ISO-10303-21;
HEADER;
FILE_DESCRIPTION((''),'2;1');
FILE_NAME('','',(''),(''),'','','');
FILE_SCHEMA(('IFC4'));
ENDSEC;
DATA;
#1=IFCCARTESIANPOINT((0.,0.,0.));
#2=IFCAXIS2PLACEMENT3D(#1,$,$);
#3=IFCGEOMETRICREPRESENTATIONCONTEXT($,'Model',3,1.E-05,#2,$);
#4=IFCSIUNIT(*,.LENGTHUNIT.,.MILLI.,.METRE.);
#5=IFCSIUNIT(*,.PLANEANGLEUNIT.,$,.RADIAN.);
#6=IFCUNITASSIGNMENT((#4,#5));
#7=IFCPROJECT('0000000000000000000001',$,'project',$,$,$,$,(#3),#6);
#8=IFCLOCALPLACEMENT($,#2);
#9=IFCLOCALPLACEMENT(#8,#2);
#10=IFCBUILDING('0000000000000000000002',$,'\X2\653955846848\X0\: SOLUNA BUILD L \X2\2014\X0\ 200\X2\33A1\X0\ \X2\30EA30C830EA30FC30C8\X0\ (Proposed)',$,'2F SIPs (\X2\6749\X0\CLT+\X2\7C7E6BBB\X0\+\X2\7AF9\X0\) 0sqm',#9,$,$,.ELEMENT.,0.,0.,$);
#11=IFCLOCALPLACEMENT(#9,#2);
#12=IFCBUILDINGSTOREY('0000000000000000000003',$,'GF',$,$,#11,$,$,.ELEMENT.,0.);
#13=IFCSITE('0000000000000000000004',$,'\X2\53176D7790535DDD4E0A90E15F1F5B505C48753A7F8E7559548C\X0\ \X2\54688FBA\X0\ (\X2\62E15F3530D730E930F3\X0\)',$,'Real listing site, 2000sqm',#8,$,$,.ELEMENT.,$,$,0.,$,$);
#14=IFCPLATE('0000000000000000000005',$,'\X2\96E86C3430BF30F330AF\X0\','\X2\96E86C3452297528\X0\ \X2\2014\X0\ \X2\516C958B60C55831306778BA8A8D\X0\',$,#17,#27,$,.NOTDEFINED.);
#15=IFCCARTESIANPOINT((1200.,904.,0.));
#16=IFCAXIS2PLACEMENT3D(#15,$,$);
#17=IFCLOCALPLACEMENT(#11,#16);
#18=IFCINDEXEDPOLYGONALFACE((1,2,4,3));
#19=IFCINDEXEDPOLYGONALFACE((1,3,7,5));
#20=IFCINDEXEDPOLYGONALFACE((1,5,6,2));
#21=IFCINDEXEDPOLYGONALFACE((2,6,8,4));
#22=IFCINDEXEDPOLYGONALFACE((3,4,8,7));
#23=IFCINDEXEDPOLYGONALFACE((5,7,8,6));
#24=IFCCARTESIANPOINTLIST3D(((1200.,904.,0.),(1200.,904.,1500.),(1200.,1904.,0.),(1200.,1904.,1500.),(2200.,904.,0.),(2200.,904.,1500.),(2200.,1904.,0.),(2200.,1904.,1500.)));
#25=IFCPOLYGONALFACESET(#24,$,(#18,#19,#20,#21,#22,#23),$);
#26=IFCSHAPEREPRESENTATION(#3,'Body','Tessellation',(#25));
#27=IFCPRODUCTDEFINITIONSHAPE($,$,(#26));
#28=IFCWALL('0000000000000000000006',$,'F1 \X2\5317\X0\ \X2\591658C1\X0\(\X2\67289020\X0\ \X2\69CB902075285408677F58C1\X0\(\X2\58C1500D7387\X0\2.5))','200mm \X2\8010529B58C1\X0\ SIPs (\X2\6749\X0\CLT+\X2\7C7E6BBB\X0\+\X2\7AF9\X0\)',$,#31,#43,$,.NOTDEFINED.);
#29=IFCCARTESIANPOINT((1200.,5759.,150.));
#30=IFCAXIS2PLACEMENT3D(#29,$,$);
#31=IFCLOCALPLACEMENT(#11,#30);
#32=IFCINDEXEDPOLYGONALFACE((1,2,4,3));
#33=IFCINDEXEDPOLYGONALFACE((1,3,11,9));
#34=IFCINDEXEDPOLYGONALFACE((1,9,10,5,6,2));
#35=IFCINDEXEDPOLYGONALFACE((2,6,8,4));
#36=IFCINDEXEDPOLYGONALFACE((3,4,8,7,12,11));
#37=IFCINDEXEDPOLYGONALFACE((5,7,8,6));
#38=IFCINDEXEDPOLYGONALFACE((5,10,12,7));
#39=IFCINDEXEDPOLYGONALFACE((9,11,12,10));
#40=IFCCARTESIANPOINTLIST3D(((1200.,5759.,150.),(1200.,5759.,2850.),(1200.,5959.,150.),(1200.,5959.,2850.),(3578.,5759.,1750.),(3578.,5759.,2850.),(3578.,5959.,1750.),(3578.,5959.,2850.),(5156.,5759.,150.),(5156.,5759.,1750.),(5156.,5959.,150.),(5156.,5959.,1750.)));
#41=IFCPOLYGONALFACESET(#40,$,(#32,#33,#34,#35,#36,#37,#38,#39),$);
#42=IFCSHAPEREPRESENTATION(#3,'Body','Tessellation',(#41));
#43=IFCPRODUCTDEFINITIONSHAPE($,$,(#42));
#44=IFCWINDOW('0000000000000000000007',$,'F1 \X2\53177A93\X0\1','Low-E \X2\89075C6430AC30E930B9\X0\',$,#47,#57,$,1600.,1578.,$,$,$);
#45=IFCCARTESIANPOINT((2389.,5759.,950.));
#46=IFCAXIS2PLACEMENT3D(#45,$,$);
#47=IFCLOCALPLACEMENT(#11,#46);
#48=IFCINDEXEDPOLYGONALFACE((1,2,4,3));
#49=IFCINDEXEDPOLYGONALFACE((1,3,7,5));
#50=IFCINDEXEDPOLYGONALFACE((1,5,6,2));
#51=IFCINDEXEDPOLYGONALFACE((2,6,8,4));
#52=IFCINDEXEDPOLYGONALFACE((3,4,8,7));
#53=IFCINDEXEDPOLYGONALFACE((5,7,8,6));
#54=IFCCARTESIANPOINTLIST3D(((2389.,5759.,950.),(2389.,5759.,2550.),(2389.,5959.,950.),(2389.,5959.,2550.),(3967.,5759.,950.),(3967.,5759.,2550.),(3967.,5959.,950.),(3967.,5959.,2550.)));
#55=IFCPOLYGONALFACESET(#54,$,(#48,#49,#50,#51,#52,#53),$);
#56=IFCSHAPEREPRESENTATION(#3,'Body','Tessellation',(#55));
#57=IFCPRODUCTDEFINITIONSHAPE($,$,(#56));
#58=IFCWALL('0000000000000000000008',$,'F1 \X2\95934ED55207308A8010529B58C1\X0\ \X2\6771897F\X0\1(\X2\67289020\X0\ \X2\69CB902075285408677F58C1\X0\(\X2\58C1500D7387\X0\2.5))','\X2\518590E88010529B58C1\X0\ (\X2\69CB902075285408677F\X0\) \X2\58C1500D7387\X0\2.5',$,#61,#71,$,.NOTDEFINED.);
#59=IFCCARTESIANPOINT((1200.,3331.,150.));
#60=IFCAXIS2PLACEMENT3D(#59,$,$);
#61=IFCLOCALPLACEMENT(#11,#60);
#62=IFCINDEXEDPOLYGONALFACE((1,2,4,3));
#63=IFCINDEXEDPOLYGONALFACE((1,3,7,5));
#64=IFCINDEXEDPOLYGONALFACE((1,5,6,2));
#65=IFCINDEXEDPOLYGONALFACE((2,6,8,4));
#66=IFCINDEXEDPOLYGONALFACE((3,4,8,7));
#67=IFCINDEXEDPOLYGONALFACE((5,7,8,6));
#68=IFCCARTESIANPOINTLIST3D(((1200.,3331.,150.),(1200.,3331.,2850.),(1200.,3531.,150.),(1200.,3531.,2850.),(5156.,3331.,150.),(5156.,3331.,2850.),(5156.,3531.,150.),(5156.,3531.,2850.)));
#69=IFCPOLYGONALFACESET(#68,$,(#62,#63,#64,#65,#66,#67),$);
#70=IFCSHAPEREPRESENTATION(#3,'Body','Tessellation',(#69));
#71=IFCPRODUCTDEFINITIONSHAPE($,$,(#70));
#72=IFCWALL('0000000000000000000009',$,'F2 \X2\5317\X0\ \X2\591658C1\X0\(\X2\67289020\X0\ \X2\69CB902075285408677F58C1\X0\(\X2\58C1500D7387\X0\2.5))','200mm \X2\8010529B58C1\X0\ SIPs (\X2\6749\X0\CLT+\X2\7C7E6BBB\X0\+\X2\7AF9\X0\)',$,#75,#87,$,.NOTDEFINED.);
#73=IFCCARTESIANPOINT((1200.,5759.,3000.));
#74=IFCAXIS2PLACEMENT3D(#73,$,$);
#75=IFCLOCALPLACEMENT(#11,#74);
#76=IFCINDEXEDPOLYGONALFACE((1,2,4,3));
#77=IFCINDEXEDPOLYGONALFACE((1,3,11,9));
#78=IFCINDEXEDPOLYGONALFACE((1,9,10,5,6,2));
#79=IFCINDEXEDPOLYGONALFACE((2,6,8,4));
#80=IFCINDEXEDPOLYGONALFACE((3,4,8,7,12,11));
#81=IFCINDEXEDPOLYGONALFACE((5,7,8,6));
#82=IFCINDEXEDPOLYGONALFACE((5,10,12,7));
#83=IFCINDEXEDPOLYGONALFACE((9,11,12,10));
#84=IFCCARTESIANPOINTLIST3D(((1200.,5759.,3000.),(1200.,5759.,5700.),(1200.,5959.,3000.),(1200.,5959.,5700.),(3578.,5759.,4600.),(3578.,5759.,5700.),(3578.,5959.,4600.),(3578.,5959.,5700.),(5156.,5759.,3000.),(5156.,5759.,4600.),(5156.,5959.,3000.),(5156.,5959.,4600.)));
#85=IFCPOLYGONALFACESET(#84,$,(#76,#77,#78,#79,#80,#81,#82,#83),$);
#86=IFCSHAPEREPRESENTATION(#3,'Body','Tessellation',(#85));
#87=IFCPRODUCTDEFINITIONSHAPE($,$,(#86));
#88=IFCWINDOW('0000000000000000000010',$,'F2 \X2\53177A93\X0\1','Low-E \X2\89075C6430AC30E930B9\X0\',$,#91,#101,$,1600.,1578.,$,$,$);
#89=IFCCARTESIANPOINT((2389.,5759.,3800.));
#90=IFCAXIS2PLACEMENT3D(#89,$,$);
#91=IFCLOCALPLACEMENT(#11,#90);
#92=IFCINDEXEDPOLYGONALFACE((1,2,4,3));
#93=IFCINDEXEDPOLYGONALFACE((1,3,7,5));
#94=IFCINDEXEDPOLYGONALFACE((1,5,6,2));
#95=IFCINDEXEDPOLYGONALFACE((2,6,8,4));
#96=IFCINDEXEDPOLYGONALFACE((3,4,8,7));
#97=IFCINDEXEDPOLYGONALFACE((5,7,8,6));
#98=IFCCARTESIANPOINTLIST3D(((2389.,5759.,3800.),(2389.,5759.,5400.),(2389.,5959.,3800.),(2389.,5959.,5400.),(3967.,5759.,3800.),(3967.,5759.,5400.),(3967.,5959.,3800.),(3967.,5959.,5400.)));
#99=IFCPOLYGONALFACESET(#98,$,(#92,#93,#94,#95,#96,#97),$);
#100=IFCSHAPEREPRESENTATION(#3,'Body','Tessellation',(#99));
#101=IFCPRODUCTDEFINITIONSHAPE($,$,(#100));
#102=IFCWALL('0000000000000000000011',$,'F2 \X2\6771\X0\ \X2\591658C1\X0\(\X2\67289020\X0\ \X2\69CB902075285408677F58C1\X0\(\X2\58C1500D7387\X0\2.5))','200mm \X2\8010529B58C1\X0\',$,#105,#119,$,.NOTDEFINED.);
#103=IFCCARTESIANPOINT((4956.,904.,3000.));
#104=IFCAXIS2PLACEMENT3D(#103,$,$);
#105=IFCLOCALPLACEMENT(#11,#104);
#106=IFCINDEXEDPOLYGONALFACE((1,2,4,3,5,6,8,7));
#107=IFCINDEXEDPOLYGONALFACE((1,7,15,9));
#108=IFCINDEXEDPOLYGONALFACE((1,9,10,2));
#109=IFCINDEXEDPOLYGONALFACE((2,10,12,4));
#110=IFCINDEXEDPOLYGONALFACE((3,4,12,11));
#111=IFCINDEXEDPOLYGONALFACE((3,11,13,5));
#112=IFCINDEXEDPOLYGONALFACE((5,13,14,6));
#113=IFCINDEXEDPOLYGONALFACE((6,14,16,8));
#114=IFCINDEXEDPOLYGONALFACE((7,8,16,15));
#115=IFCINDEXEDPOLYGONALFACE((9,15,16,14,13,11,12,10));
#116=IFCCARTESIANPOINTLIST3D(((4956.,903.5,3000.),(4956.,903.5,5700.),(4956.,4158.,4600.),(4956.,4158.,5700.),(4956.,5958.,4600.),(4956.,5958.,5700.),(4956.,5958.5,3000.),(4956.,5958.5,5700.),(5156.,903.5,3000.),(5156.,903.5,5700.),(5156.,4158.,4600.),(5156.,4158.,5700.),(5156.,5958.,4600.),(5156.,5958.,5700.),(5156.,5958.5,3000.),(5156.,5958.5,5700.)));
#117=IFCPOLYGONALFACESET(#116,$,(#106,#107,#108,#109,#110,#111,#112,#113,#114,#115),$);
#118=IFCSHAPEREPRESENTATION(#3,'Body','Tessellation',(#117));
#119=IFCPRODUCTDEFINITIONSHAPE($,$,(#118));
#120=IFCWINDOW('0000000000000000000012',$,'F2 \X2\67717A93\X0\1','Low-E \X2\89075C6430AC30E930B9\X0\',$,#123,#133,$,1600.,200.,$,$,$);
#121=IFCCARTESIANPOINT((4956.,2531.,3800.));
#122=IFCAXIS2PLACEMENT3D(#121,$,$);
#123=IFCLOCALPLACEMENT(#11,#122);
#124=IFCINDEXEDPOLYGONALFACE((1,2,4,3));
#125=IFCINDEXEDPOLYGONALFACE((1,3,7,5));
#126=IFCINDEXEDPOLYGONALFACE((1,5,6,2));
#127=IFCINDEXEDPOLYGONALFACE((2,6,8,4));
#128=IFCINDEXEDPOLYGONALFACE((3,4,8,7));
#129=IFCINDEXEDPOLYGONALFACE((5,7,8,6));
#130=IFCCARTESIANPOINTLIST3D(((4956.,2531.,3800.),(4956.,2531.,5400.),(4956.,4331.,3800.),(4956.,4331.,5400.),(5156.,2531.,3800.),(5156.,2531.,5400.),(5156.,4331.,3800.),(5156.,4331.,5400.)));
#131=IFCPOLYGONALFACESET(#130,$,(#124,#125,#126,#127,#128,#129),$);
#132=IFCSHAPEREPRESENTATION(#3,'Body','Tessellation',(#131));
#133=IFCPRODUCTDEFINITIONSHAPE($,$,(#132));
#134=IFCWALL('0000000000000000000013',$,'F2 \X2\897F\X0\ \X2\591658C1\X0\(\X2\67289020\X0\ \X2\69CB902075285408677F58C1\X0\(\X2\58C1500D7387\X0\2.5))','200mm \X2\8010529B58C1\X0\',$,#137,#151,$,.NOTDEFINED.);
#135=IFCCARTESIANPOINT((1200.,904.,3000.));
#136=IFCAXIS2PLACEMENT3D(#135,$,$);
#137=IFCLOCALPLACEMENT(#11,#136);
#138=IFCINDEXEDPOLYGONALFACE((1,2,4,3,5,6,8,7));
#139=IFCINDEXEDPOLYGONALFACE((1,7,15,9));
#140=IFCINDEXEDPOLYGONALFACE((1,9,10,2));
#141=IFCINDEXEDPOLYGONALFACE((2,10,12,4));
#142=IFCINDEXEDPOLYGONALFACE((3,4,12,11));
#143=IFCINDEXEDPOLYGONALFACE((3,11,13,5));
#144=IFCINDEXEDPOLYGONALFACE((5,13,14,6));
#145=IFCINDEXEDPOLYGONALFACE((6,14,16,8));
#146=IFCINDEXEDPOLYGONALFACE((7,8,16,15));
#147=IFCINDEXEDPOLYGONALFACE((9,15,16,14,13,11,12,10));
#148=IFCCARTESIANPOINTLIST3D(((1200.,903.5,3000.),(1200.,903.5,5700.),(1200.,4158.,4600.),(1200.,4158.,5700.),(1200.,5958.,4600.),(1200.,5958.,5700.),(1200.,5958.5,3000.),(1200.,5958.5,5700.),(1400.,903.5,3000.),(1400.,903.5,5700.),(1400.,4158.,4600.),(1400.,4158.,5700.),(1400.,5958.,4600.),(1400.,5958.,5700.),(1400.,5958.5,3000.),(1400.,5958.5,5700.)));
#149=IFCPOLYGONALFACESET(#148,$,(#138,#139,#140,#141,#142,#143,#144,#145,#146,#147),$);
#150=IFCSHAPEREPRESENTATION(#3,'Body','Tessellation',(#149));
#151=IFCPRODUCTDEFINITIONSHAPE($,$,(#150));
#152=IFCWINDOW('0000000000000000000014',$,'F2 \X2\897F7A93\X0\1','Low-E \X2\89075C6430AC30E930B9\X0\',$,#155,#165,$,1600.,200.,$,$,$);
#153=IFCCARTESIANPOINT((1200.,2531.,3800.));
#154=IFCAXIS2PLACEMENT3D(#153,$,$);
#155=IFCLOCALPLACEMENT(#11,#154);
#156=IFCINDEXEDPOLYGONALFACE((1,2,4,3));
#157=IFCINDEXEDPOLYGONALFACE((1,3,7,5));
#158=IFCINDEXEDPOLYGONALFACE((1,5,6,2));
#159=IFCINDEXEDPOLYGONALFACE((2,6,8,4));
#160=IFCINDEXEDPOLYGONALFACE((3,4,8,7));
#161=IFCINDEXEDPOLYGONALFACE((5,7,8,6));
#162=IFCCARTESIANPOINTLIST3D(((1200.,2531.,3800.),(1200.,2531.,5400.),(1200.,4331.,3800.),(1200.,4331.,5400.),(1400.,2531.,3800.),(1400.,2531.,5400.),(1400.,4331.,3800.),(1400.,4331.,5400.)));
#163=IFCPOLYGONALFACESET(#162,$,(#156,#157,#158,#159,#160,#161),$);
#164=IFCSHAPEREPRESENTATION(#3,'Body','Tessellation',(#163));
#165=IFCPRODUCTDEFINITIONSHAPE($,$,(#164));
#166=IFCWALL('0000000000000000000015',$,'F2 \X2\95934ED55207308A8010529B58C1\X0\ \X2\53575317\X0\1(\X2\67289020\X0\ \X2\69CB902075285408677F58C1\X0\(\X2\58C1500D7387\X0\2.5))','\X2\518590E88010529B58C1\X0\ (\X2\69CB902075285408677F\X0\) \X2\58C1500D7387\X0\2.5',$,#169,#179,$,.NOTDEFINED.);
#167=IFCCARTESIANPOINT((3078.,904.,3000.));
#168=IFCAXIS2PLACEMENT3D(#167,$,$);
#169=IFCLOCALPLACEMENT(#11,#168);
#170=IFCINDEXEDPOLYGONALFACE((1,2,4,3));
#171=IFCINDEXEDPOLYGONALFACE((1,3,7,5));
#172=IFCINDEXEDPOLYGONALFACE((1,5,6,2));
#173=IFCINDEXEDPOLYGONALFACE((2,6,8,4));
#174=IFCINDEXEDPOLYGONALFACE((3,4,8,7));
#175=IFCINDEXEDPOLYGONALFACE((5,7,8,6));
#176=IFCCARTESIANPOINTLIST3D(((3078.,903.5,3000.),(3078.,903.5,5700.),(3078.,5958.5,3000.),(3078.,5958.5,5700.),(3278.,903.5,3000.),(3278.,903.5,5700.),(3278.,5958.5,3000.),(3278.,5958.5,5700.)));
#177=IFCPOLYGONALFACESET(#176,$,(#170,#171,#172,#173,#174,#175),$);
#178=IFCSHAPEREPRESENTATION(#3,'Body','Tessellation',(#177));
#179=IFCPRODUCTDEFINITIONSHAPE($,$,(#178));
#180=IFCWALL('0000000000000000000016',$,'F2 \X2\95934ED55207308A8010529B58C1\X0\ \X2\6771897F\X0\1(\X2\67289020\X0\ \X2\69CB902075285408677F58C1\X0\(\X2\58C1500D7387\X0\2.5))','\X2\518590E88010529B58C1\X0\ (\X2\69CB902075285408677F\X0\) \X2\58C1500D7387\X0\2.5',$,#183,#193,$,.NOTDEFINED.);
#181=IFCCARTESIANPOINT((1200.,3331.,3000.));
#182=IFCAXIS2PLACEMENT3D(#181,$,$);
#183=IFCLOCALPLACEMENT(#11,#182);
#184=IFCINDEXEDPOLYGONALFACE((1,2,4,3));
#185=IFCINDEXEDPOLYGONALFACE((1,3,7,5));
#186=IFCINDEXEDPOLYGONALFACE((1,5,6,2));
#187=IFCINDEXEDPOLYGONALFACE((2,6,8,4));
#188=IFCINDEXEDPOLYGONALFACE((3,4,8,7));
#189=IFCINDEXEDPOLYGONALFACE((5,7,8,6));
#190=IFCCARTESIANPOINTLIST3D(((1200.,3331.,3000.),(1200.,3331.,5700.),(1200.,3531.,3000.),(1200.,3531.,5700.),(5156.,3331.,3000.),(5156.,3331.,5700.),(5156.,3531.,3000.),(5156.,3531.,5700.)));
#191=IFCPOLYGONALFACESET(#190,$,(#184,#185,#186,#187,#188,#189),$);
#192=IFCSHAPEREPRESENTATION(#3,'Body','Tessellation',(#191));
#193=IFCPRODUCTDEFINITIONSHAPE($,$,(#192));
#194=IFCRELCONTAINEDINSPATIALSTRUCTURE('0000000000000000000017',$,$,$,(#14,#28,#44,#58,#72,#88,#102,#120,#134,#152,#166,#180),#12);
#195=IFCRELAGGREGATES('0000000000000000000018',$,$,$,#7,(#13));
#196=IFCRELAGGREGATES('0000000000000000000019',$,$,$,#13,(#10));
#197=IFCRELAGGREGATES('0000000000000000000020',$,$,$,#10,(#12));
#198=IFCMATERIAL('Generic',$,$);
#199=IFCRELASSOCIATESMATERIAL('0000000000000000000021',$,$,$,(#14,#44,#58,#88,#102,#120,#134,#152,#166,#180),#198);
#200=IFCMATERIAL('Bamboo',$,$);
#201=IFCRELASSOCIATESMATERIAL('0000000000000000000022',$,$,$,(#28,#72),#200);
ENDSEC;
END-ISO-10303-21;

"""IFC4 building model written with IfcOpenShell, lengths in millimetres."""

from ifc_helpers import new_model, si_unit, frame, frame_2d, origin, place, context, project, spatial, rectangle, extrude, material, element, fill, save


model = new_model("IFC4")

# Units and contexts
model_context = context("Model", 3, precision=1e-05, world=origin())
ifc_project = project(units=[si_unit("LENGTHUNIT", "METRE", prefix="MILLI"), si_unit("PLANEANGLEUNIT", "RADIAN")], contexts=[model_context])

# Site, building, storey
site_placement = place(None, origin())
site = spatial("IfcSite", under=ifc_project, at=site_placement, Name="北海道川上郡弟子屈町美留和 周辺 (拡張プラン)", ObjectType="Real listing site, 2000sqm", CompositionType="ELEMENT", RefElevation=0.0)
building_placement = place(site_placement, origin())
building = spatial("IfcBuilding", under=site, at=building_placement, Name="改善案: SOLUNA BUILD L — 200㎡ リトリート (Proposed)", ObjectType="2F SIPs (杉CLT+籾殻+竹) 0sqm", CompositionType="ELEMENT", ElevationOfRefHeight=0.0, ElevationOfTerrain=0.0)
storey_placement = place(building_placement, origin())
storey = spatial("IfcBuildingStorey", under=building, at=storey_placement, Name="GF", CompositionType="ELEMENT", Elevation=0.0)

# Plate
ifc_material_1 = material(Name="Generic")
plate_placement = place(storey_placement, frame((1200.0, 904.0, 0.0)))
element("IfcPlate", 1, at=plate_placement, inside=storey, material=ifc_material_1, Name="雨水タンク", Description="雨水利用 — 公開情報で確認", PredefinedType="NOTDEFINED", context=model_context, shape_type="SweptSolid", body=[
    extrude(rectangle(XDim=1000.0, YDim=1000.0, at=frame_2d((500.0, 500.0))), frame((1200.0, 904.0, 0.0)), (0.0, 0.0, 1.0), 1500.0),
])

# Wall, opening, window
ifc_material_2 = material(Name="Bamboo")
wall_1_placement = place(storey_placement, frame((1200.0, 5759.0, 150.0)))
wall_1 = element("IfcWall", 2, at=wall_1_placement, inside=storey, material=ifc_material_2, Name="F1 北 外壁(木造 構造用合板壁(壁倍率2.5))", Description="200mm 耐力壁 SIPs (杉CLT+籾殻+竹)", PredefinedType="NOTDEFINED", context=model_context, shape_type="SweptSolid", body=[
    extrude(rectangle(XDim=3956.0, YDim=200.0, at=frame_2d((1978.0, 100.0))), frame((1200.0, 5759.0, 150.0)), (0.0, 0.0, 1.0), 2700.0),
])
opening_1_placement = place(storey_placement, frame((2389.0, 5759.0, 950.0)))
opening_1 = element("IfcOpeningElement", 3, at=opening_1_placement, cuts=wall_1, PredefinedType="NOTDEFINED", context=model_context, shape_type="SweptSolid", body=[
    extrude(rectangle(XDim=1578.0, YDim=200.0, at=frame_2d((789.0, 100.0))), frame((2389.0, 5759.0, 950.0)), (0.0, 0.0, 1.0), 1600.0),
])
window_1_placement = place(storey_placement, frame((2389.0, 5759.0, 950.0)))
window_1 = element("IfcWindow", 4, at=window_1_placement, inside=storey, material=ifc_material_1, Name="F1 北窓1", Description="Low-E 複層ガラス", OverallHeight=1600.0, OverallWidth=1578.0, context=model_context, shape_type="SweptSolid", body=[
    extrude(rectangle(XDim=1578.0, YDim=200.0, at=frame_2d((789.0, 100.0))), frame((2389.0, 5759.0, 950.0)), (0.0, 0.0, 1.0), 1600.0),
])
fill(opening_1, window_1)

# Wall
wall_2_placement = place(storey_placement, frame((1200.0, 3331.0, 150.0)))
element("IfcWall", 5, at=wall_2_placement, inside=storey, material=ifc_material_1, Name="F1 間仕切り耐力壁 東西1(木造 構造用合板壁(壁倍率2.5))", Description="内部耐力壁 (構造用合板) 壁倍率2.5", PredefinedType="NOTDEFINED", context=model_context, shape_type="SweptSolid", body=[
    extrude(rectangle(XDim=3956.0, YDim=200.0, at=frame_2d((1978.0, 100.0))), frame((1200.0, 3331.0, 150.0)), (0.0, 0.0, 1.0), 2700.0),
])

# Walls, openings, windows
wall_3_placement = place(storey_placement, frame((1200.0, 5759.0, 3000.0)))
wall_3 = element("IfcWall", 6, at=wall_3_placement, inside=storey, material=ifc_material_2, Name="F2 北 外壁(木造 構造用合板壁(壁倍率2.5))", Description="200mm 耐力壁 SIPs (杉CLT+籾殻+竹)", PredefinedType="NOTDEFINED", context=model_context, shape_type="SweptSolid", body=[
    extrude(rectangle(XDim=3956.0, YDim=200.0, at=frame_2d((1978.0, 100.0))), frame((1200.0, 5759.0, 3000.0)), (0.0, 0.0, 1.0), 2700.0),
])
opening_2_placement = place(storey_placement, frame((2389.0, 5759.0, 3800.0)))
opening_2 = element("IfcOpeningElement", 7, at=opening_2_placement, cuts=wall_3, PredefinedType="NOTDEFINED", context=model_context, shape_type="SweptSolid", body=[
    extrude(rectangle(XDim=1578.0, YDim=200.0, at=frame_2d((789.0, 100.0))), frame((2389.0, 5759.0, 3800.0)), (0.0, 0.0, 1.0), 1600.0),
])
window_2_placement = place(storey_placement, frame((2389.0, 5759.0, 3800.0)))
window_2 = element("IfcWindow", 8, at=window_2_placement, inside=storey, material=ifc_material_1, Name="F2 北窓1", Description="Low-E 複層ガラス", OverallHeight=1600.0, OverallWidth=1578.0, context=model_context, shape_type="SweptSolid", body=[
    extrude(rectangle(XDim=1578.0, YDim=200.0, at=frame_2d((789.0, 100.0))), frame((2389.0, 5759.0, 3800.0)), (0.0, 0.0, 1.0), 1600.0),
])
fill(opening_2, window_2)
wall_4_placement = place(storey_placement, frame((4956.0, 904.0, 3000.0)))
wall_4 = element("IfcWall", 9, at=wall_4_placement, inside=storey, material=ifc_material_1, Name="F2 東 外壁(木造 構造用合板壁(壁倍率2.5))", Description="200mm 耐力壁", PredefinedType="NOTDEFINED", context=model_context, shape_type="SweptSolid", body=[
    extrude(rectangle(XDim=200.0, YDim=5055.0, at=frame_2d((100.0, 2527.0))), frame((4956.0, 904.0, 3000.0)), (0.0, 0.0, 1.0), 2700.0),
])
opening_3_placement = place(storey_placement, frame((4956.0, 2531.0, 3800.0)))
opening_3 = element("IfcOpeningElement", 10, at=opening_3_placement, cuts=wall_4, PredefinedType="NOTDEFINED", context=model_context, shape_type="SweptSolid", body=[
    extrude(rectangle(XDim=200.0, YDim=1800.0, at=frame_2d((100.0, 900.0))), frame((4956.0, 2531.0, 3800.0)), (0.0, 0.0, 1.0), 1600.0),
])
window_3_placement = place(storey_placement, frame((4956.0, 2531.0, 3800.0)))
window_3 = element("IfcWindow", 11, at=window_3_placement, inside=storey, material=ifc_material_1, Name="F2 東窓1", Description="Low-E 複層ガラス", OverallHeight=1600.0, OverallWidth=200.0, context=model_context, shape_type="SweptSolid", body=[
    extrude(rectangle(XDim=200.0, YDim=1800.0, at=frame_2d((100.0, 900.0))), frame((4956.0, 2531.0, 3800.0)), (0.0, 0.0, 1.0), 1600.0),
])
fill(opening_3, window_3)
wall_5_placement = place(storey_placement, frame((1200.0, 904.0, 3000.0)))
wall_5 = element("IfcWall", 12, at=wall_5_placement, inside=storey, material=ifc_material_1, Name="F2 西 外壁(木造 構造用合板壁(壁倍率2.5))", Description="200mm 耐力壁", PredefinedType="NOTDEFINED", context=model_context, shape_type="SweptSolid", body=[
    extrude(rectangle(XDim=200.0, YDim=5055.0, at=frame_2d((100.0, 2527.0))), frame((1200.0, 904.0, 3000.0)), (0.0, 0.0, 1.0), 2700.0),
])
opening_4_placement = place(storey_placement, frame((1200.0, 2531.0, 3800.0)))
opening_4 = element("IfcOpeningElement", 13, at=opening_4_placement, cuts=wall_5, PredefinedType="NOTDEFINED", context=model_context, shape_type="SweptSolid", body=[
    extrude(rectangle(XDim=200.0, YDim=1800.0, at=frame_2d((100.0, 900.0))), frame((1200.0, 2531.0, 3800.0)), (0.0, 0.0, 1.0), 1600.0),
])
window_4_placement = place(storey_placement, frame((1200.0, 2531.0, 3800.0)))
window_4 = element("IfcWindow", 14, at=window_4_placement, inside=storey, material=ifc_material_1, Name="F2 西窓1", Description="Low-E 複層ガラス", OverallHeight=1600.0, OverallWidth=200.0, context=model_context, shape_type="SweptSolid", body=[
    extrude(rectangle(XDim=200.0, YDim=1800.0, at=frame_2d((100.0, 900.0))), frame((1200.0, 2531.0, 3800.0)), (0.0, 0.0, 1.0), 1600.0),
])
fill(opening_4, window_4)

# Walls
wall_6_placement = place(storey_placement, frame((3078.0, 904.0, 3000.0)))
element("IfcWall", 15, at=wall_6_placement, inside=storey, material=ifc_material_1, Name="F2 間仕切り耐力壁 南北1(木造 構造用合板壁(壁倍率2.5))", Description="内部耐力壁 (構造用合板) 壁倍率2.5", PredefinedType="NOTDEFINED", context=model_context, shape_type="SweptSolid", body=[
    extrude(rectangle(XDim=200.0, YDim=5055.0, at=frame_2d((100.0, 2527.0))), frame((3078.0, 904.0, 3000.0)), (0.0, 0.0, 1.0), 2700.0),
])
wall_7_placement = place(storey_placement, frame((1200.0, 3331.0, 3000.0)))
element("IfcWall", 16, at=wall_7_placement, inside=storey, material=ifc_material_1, Name="F2 間仕切り耐力壁 東西1(木造 構造用合板壁(壁倍率2.5))", Description="内部耐力壁 (構造用合板) 壁倍率2.5", PredefinedType="NOTDEFINED", context=model_context, shape_type="SweptSolid", body=[
    extrude(rectangle(XDim=3956.0, YDim=200.0, at=frame_2d((1978.0, 100.0))), frame((1200.0, 3331.0, 3000.0)), (0.0, 0.0, 1.0), 2700.0),
])

save(model, "model.ifc")
